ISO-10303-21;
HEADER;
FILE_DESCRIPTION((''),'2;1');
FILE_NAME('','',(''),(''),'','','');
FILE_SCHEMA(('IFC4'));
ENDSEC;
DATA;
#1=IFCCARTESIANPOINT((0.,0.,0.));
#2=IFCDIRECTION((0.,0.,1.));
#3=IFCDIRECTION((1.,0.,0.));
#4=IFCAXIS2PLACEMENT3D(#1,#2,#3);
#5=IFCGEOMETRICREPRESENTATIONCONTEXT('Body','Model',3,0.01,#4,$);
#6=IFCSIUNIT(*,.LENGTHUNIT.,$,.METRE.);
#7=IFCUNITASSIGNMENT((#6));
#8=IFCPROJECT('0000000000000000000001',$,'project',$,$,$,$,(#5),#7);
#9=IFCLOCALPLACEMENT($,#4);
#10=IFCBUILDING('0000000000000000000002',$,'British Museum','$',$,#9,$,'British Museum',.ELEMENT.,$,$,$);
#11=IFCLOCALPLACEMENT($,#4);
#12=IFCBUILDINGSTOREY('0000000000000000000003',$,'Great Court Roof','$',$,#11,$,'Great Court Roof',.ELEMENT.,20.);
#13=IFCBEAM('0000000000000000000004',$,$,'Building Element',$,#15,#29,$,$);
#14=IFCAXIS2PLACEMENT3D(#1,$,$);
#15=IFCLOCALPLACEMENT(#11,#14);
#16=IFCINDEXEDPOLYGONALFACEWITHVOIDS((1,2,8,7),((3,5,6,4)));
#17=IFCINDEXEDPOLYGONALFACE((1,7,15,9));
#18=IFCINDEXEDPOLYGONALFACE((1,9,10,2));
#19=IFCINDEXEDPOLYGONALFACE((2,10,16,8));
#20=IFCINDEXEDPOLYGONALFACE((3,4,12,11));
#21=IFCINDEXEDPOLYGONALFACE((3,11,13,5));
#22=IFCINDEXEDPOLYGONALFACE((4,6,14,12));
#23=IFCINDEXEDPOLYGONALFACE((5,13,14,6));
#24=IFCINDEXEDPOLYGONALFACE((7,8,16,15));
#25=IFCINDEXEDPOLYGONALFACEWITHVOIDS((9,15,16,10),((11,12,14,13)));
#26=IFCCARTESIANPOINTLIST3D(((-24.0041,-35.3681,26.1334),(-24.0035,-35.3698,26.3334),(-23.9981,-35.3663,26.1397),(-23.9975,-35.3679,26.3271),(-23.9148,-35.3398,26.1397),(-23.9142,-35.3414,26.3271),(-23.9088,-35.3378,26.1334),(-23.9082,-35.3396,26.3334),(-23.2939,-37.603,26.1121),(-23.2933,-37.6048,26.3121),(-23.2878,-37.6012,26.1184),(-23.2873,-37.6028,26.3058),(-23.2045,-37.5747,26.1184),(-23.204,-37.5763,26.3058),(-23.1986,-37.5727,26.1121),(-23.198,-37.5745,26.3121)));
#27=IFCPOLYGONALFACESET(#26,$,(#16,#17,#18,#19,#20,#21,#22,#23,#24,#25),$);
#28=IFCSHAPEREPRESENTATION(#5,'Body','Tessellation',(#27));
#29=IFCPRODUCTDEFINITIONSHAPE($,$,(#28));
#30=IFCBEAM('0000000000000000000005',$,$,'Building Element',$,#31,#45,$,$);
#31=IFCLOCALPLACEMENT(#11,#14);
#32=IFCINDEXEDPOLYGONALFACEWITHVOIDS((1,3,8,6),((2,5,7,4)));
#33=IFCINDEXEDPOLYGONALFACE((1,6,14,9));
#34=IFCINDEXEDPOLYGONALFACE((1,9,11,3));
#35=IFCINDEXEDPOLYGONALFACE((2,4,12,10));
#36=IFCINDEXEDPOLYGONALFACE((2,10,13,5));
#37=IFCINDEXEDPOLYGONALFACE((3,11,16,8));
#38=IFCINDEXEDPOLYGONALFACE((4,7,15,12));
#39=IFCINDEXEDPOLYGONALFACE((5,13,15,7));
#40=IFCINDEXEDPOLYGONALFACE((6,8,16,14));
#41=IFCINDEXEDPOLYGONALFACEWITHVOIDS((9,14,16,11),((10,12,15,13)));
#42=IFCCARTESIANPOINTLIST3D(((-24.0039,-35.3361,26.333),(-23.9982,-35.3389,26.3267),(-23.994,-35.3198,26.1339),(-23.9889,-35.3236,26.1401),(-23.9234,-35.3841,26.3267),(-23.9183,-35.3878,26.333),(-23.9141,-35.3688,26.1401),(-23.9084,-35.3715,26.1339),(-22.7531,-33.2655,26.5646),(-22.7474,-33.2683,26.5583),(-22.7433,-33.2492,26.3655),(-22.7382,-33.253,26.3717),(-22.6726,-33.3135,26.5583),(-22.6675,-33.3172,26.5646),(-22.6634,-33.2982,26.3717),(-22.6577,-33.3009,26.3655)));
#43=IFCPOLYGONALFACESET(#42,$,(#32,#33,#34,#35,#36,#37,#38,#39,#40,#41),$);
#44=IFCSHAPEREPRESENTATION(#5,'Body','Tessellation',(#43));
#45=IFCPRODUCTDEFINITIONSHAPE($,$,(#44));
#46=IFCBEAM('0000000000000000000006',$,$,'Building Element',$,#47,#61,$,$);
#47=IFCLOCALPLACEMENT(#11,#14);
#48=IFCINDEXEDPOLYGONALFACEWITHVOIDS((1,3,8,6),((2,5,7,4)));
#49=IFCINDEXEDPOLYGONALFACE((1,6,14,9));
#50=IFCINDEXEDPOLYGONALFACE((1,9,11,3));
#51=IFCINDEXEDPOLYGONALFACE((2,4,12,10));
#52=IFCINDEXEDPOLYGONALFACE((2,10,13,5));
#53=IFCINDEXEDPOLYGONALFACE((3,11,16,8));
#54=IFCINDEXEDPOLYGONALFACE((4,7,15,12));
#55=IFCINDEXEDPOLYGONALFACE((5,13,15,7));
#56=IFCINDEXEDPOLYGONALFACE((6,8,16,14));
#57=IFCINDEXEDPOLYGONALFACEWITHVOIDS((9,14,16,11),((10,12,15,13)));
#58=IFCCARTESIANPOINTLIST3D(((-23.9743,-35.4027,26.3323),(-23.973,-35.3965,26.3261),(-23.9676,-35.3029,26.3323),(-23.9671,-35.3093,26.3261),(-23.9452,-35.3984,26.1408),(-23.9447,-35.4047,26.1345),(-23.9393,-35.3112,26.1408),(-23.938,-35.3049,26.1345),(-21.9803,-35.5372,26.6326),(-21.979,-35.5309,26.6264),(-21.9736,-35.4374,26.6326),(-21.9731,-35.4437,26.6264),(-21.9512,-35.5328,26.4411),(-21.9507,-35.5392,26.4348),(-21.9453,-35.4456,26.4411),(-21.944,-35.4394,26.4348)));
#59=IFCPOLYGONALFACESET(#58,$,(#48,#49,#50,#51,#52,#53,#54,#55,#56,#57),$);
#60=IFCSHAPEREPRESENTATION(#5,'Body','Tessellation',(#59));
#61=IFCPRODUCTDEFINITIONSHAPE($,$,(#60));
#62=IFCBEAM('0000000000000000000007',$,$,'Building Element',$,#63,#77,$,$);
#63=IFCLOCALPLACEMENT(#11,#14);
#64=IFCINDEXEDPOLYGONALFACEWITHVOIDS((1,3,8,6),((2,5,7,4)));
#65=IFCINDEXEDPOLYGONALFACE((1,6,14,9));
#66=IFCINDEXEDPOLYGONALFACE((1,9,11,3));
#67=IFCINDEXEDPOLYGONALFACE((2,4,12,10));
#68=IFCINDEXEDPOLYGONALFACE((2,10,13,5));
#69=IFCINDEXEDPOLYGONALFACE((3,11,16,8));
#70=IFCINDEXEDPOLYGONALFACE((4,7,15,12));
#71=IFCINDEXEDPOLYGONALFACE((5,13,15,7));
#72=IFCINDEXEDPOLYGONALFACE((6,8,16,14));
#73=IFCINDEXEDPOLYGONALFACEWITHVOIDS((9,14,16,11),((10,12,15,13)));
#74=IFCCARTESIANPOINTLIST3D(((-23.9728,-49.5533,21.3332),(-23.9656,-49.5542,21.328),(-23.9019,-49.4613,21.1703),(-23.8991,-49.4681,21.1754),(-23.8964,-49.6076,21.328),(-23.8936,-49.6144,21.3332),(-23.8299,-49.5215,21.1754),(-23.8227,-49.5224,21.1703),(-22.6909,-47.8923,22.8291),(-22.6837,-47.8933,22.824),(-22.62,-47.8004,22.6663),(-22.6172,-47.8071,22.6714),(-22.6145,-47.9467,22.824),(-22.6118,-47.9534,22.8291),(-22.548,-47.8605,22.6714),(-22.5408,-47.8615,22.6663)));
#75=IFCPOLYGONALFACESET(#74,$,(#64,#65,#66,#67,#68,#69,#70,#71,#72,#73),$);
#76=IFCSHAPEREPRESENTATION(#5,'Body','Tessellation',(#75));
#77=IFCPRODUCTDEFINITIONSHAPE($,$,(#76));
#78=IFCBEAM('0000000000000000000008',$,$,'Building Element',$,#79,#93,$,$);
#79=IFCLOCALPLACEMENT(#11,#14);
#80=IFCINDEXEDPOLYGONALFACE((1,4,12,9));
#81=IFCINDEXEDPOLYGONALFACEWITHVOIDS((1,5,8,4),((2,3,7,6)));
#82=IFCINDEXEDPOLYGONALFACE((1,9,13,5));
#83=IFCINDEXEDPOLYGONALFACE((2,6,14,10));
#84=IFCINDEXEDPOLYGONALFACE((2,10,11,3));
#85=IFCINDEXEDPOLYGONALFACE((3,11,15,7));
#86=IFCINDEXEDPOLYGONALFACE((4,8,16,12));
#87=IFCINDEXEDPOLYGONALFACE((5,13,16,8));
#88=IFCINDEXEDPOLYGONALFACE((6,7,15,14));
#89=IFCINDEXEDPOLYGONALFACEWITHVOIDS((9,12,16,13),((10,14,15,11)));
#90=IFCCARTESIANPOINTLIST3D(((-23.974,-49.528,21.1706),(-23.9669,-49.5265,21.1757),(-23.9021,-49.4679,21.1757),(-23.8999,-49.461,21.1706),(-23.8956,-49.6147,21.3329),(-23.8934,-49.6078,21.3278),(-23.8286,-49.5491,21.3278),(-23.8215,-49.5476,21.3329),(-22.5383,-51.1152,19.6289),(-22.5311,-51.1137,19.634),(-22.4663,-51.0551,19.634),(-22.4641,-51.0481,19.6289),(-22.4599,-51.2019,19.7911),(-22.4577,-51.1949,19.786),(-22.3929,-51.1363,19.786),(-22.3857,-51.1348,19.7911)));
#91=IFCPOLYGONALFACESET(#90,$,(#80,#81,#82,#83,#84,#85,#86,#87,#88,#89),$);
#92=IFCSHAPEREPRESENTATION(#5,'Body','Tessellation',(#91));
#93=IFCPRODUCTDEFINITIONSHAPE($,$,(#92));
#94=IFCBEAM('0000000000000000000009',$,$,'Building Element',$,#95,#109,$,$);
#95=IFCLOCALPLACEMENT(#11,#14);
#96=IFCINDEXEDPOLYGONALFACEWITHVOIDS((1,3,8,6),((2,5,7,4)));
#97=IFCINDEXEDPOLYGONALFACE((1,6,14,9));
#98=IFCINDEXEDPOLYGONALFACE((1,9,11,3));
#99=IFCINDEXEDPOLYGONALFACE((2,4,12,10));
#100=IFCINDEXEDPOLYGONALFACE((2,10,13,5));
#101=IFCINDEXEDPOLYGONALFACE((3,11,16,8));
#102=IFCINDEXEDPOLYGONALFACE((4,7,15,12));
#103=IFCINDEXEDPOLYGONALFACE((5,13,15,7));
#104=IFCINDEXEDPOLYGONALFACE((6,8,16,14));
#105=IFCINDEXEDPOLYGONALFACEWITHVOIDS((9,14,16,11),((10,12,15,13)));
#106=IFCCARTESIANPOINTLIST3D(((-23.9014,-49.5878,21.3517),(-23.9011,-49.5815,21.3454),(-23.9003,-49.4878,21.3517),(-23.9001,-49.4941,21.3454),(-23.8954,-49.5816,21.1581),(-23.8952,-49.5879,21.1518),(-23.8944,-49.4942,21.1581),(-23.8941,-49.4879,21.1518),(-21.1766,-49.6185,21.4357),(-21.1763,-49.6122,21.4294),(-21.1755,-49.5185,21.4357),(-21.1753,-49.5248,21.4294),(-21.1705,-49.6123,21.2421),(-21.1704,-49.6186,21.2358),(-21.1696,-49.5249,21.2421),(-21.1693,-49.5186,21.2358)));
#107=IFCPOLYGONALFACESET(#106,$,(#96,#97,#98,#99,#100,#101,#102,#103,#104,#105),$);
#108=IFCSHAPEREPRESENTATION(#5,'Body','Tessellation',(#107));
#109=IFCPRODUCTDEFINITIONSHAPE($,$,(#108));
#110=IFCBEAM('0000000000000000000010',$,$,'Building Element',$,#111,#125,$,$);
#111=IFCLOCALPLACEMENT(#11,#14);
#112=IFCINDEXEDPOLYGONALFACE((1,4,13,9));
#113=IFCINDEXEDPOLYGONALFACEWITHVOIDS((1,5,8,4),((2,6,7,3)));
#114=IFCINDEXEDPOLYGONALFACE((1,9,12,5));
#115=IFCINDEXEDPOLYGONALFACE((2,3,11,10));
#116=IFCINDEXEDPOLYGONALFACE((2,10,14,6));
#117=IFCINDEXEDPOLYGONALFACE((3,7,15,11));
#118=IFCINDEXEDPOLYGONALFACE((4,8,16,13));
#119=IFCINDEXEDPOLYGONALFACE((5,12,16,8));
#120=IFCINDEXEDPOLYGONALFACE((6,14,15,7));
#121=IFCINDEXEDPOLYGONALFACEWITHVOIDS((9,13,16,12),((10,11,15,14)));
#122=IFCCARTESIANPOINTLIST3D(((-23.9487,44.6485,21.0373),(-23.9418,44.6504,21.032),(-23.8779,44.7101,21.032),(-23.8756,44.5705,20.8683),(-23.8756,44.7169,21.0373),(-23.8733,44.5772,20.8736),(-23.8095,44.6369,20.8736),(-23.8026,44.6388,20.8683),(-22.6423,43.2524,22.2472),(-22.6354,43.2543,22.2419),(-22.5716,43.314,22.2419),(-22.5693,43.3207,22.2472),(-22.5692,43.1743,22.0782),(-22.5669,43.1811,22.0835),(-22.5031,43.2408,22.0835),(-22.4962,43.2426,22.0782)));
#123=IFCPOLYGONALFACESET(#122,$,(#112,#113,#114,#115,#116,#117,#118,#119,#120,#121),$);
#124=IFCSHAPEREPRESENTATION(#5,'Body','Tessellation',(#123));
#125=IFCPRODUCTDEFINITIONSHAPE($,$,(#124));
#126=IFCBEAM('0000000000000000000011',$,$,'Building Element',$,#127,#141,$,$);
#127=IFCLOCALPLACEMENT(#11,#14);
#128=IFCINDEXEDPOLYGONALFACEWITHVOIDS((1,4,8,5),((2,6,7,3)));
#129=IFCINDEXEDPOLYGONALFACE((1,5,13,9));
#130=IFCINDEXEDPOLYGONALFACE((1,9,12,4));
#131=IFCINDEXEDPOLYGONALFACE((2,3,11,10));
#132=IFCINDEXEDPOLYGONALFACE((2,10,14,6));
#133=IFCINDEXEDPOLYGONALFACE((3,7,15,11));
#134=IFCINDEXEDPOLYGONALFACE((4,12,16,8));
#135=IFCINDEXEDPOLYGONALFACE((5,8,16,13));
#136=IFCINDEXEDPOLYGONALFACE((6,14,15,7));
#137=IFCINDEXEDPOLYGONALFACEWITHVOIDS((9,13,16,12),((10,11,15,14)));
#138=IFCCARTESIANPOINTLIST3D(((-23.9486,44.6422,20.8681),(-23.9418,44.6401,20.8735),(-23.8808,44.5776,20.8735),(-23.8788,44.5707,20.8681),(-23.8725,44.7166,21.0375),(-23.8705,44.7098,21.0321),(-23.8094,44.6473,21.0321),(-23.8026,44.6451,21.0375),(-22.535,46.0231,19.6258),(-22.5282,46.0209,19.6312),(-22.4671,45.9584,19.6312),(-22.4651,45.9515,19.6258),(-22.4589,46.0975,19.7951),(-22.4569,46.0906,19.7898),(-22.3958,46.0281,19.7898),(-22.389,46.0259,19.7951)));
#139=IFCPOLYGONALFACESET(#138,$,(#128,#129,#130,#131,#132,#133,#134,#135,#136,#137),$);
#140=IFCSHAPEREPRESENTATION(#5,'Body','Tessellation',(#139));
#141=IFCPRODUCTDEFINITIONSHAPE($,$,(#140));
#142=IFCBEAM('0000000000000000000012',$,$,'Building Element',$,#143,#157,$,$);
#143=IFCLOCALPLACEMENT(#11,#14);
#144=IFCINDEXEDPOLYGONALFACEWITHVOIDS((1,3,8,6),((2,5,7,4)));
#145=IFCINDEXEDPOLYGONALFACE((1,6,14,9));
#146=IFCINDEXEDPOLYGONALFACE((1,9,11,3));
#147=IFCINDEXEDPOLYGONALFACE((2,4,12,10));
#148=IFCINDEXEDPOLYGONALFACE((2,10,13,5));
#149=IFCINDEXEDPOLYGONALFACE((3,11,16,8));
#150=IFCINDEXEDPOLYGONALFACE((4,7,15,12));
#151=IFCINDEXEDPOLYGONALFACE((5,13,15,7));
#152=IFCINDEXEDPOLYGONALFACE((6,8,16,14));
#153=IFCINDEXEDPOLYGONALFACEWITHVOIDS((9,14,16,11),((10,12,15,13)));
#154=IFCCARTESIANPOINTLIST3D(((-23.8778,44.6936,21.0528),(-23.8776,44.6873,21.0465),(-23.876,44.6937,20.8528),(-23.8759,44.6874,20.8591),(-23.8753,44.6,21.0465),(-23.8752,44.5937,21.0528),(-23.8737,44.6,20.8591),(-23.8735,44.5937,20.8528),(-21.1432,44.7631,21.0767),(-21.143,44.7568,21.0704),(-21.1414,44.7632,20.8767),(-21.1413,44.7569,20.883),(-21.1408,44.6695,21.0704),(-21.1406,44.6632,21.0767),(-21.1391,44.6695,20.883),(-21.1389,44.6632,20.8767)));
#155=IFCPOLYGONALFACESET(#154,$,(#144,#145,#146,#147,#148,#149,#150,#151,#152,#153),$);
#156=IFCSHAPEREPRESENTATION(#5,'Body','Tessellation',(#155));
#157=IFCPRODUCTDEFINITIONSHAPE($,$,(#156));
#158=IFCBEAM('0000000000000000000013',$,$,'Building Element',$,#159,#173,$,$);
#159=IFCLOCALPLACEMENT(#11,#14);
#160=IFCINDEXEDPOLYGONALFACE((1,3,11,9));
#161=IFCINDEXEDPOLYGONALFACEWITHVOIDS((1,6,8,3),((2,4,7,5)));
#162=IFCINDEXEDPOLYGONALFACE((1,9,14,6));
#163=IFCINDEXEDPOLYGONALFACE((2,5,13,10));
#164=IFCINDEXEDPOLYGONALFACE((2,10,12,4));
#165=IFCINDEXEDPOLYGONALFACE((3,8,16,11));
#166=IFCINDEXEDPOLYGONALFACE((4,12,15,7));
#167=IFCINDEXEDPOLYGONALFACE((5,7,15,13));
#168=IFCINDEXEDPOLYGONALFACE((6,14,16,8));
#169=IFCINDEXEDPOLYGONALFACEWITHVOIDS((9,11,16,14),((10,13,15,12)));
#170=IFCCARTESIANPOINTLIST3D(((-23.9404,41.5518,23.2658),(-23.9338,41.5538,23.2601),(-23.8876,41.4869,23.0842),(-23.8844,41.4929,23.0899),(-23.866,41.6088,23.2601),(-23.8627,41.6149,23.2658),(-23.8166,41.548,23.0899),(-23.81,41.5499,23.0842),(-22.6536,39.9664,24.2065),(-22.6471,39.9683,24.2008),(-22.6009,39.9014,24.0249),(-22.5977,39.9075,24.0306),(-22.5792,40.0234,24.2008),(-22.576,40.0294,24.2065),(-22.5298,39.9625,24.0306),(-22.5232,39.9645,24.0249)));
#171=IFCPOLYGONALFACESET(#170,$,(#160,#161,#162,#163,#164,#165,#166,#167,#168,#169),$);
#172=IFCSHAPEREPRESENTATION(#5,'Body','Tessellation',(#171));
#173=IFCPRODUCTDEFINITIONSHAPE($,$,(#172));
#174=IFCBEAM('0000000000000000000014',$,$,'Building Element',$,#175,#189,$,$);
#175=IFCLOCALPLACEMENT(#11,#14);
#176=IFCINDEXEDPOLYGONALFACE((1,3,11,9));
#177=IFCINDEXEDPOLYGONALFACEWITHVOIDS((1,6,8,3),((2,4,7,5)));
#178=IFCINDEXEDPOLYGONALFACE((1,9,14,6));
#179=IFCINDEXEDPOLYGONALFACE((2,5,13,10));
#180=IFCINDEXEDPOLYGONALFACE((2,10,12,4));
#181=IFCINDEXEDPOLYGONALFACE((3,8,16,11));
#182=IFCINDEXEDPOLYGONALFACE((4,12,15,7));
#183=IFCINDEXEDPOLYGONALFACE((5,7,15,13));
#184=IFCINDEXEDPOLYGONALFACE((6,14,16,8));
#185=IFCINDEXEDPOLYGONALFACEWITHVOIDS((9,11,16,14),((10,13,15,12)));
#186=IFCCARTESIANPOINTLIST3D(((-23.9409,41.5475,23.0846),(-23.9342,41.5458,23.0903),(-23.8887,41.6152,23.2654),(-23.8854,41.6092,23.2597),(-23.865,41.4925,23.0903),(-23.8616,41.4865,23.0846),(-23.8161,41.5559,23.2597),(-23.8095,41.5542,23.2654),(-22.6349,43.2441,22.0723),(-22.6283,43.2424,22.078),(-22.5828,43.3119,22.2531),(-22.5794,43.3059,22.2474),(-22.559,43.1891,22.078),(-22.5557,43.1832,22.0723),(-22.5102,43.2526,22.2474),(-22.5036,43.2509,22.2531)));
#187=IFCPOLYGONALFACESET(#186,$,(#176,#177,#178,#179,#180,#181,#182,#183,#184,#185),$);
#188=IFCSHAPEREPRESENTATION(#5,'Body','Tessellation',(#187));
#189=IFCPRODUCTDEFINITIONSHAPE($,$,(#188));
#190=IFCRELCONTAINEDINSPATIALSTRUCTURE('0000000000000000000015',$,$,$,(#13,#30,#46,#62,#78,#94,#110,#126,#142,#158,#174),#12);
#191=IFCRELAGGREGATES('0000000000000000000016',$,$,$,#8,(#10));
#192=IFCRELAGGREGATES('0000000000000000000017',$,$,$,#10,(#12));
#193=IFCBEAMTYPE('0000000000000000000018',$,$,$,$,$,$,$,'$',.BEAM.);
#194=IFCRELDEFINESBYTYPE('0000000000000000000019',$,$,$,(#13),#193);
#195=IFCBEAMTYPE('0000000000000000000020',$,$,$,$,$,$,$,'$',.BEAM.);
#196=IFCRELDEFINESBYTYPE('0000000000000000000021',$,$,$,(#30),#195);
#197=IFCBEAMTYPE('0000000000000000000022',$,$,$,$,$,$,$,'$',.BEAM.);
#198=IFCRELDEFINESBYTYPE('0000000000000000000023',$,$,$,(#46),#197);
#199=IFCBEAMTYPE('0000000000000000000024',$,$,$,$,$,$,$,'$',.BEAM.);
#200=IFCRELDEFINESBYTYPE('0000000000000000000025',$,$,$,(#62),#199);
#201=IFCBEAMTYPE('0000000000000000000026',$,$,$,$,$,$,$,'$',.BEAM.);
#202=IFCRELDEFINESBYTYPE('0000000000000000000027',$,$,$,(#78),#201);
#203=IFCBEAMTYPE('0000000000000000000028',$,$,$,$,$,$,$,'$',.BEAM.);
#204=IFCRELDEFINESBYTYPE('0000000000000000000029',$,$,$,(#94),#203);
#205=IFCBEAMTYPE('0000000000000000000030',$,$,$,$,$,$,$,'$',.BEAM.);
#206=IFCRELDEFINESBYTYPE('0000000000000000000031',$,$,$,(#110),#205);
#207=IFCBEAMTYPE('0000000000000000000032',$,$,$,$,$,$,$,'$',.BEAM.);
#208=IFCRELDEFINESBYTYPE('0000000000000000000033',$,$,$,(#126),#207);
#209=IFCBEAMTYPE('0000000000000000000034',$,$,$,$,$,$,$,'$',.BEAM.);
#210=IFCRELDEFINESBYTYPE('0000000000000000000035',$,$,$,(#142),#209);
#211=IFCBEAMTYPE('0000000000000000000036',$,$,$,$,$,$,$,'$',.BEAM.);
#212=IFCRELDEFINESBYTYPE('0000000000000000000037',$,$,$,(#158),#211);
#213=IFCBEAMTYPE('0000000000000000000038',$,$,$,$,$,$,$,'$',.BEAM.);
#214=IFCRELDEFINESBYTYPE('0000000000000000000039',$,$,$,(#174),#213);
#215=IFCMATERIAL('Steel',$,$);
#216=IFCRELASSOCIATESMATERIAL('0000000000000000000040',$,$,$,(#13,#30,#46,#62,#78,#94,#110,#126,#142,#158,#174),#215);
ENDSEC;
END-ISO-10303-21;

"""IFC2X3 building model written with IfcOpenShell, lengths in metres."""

from ifc_helpers import new_model, si_unit, frame, origin_with_axes, origin_2d, place, context, project, spatial, hollow_rectangle, extrude, material, type_object, element, save


model = new_model("IFC2X3")

# Units and contexts
model_context = context("Model", 3, precision=0.01, world=origin_with_axes(), identifier="Body")
ifc_project = project(units=[si_unit("LENGTHUNIT", "METRE")], contexts=[model_context])

# Building, storey
building_placement = place(None, origin_with_axes())
building = spatial("IfcBuilding", under=ifc_project, at=building_placement, Name="British Museum", Description="$", LongName="British Museum", CompositionType="ELEMENT")
storey_placement = place(None, origin_with_axes())
storey = spatial("IfcBuildingStorey", under=building, at=storey_placement, Name="Great Court Roof", Description="$", LongName="Great Court Roof", CompositionType="ELEMENT", Elevation=20.0)

# Beams
ifc_material = material(Name="Steel")
beam_type_1 = type_object("IfcBeamType", ElementType="$", PredefinedType="BEAM")
beam_1_placement = place(None, origin_with_axes())
element("IfcBeam", 1, at=beam_1_placement, inside=storey, type_object=beam_type_1, material=ifc_material, Description="Building Element", context=model_context, shape_type="SweptSolid", body=[
    extrude(hollow_rectangle(XDim=0.1, YDim=0.2, WallThickness=0.0063, InnerFilletRadius=-0.0063, OuterFilletRadius=0.0, at=origin_2d()), frame((-23.9561, -35.3538, 26.2334), z_axis=(0.302842, -0.952997, -0.009081), x_axis=(0.953037, 0.302855, 0.0)), (0.0, 0.0, 1.0), 2.3452),
])
beam_type_2 = type_object("IfcBeamType", ElementType="$", PredefinedType="BEAM")
beam_2_placement = place(None, origin_with_axes())
element("IfcBeam", 2, at=beam_2_placement, inside=storey, type_object=beam_type_2, material=ifc_material, Description="Building Element", context=model_context, shape_type="SweptSolid", body=[
    extrude(hollow_rectangle(XDim=0.1, YDim=0.2, WallThickness=0.0063, InnerFilletRadius=-0.0063, OuterFilletRadius=0.0, at=origin_2d()), frame((-23.9561, -35.3538, 26.2334), z_axis=(0.514682, 0.852068, 0.095308), x_axis=(-0.855964, 0.517035, 0.0)), (0.0, 0.0, 1.0), 2.4301),
])
beam_type_3 = type_object("IfcBeamType", ElementType="$", PredefinedType="BEAM")
beam_3_placement = place(None, origin_with_axes())
element("IfcBeam", 3, at=beam_3_placement, inside=storey, type_object=beam_type_3, material=ifc_material, Description="Building Element", context=model_context, shape_type="SweptSolid", body=[
    extrude(hollow_rectangle(XDim=0.1, YDim=0.2, WallThickness=0.0063, InnerFilletRadius=-0.0063, OuterFilletRadius=0.0, at=origin_2d()), frame((-23.9561, -35.3538, 26.2334), z_axis=(0.986657, -0.066531, 0.1486), x_axis=(0.067278, 0.997734, 0.0)), (0.0, 0.0, 1.0), 2.021),
])
beam_type_4 = type_object("IfcBeamType", ElementType="$", PredefinedType="BEAM")
beam_4_placement = place(None, origin_with_axes())
element("IfcBeam", 4, at=beam_4_placement, inside=storey, type_object=beam_type_4, material=ifc_material, Description="Building Element", context=model_context, shape_type="SweptSolid", body=[
    extrude(hollow_rectangle(XDim=0.1, YDim=0.2, WallThickness=0.0063, InnerFilletRadius=-0.0063, OuterFilletRadius=0.0, at=origin_2d()), frame((-23.8977, -49.5378, 21.2517), z_axis=(0.497468, 0.644578, 0.580555), x_axis=(-0.79165, 0.610975, 0.0)), (0.0, 0.0, 1.0), 2.5768),
])
beam_type_5 = type_object("IfcBeamType", ElementType="$", PredefinedType="BEAM")
beam_5_placement = place(None, origin_with_axes())
element("IfcBeam", 5, at=beam_5_placement, inside=storey, type_object=beam_type_5, material=ifc_material, Description="Building Element", context=model_context, shape_type="SweptSolid", body=[
    extrude(hollow_rectangle(XDim=0.1, YDim=0.2, WallThickness=0.0063, InnerFilletRadius=-0.0063, OuterFilletRadius=0.0, at=origin_2d()), frame((-23.8977, -49.5378, 21.2517), z_axis=(0.544321, -0.601723, -0.584503), x_axis=(0.741594, 0.670849, 0.0)), (0.0, 0.0, 1.0), 2.6377),
])
beam_type_6 = type_object("IfcBeamType", ElementType="$", PredefinedType="BEAM")
beam_6_placement = place(None, origin_with_axes())
element("IfcBeam", 6, at=beam_6_placement, inside=storey, type_object=beam_type_6, material=ifc_material, Description="Building Element", context=model_context, shape_type="SweptSolid", body=[
    extrude(hollow_rectangle(XDim=0.1, YDim=0.2, WallThickness=0.0063, InnerFilletRadius=-0.0063, OuterFilletRadius=0.0, at=origin_2d()), frame((-23.8977, -49.5378, 21.2517), z_axis=(0.999461, -0.011261, 0.030821), x_axis=(0.011266, 0.999937, 0.0)), (0.0, 0.0, 1.0), 2.7263),
])
beam_type_7 = type_object("IfcBeamType", ElementType="$", PredefinedType="BEAM")
beam_7_placement = place(None, origin_with_axes())
element("IfcBeam", 7, at=beam_7_placement, inside=storey, type_object=beam_type_7, material=ifc_material, Description="Building Element", context=model_context, shape_type="SweptSolid", body=[
    extrude(hollow_rectangle(XDim=0.1, YDim=0.2, WallThickness=0.0063, InnerFilletRadius=-0.0063, OuterFilletRadius=0.0, at=origin_2d()), frame((-23.8756, 44.6437, 20.9528), z_axis=(0.577362, -0.617034, 0.534717), x_axis=(0.730191, 0.683243, 0.0)), (0.0, 0.0, 1.0), 2.2627),
])
beam_type_8 = type_object("IfcBeamType", ElementType="$", PredefinedType="BEAM")
beam_8_placement = place(None, origin_with_axes())
element("IfcBeam", 8, at=beam_8_placement, inside=storey, type_object=beam_type_8, material=ifc_material, Description="Building Element", context=model_context, shape_type="SweptSolid", body=[
    extrude(hollow_rectangle(XDim=0.1, YDim=0.2, WallThickness=0.0063, InnerFilletRadius=-0.0063, OuterFilletRadius=0.0, at=origin_2d()), frame((-23.8756, 44.6437, 20.9528), z_axis=(0.605619, 0.591572, -0.53223), x_axis=(-0.698762, 0.715354, 0.0)), (0.0, 0.0, 1.0), 2.3342),
])
beam_type_9 = type_object("IfcBeamType", ElementType="$", PredefinedType="BEAM")
beam_9_placement = place(None, origin_with_axes())
element("IfcBeam", 9, at=beam_9_placement, inside=storey, type_object=beam_type_9, material=ifc_material, Description="Building Element", context=model_context, shape_type="SweptSolid", body=[
    extrude(hollow_rectangle(XDim=0.1, YDim=0.2, WallThickness=0.0063, InnerFilletRadius=-0.0063, OuterFilletRadius=0.0, at=origin_2d()), frame((-23.8756, 44.6437, 20.9528), z_axis=(0.999639, 0.025412, 0.008721), x_axis=(-0.025413, 0.999677, 0.0)), (0.0, 0.0, 1.0), 2.7356),
])
beam_type_10 = type_object("IfcBeamType", ElementType="$", PredefinedType="BEAM")
beam_10_placement = place(None, origin_with_axes())
element("IfcBeam", 10, at=beam_10_placement, inside=storey, type_object=beam_type_10, material=ifc_material, Description="Building Element", context=model_context, shape_type="SweptSolid", body=[
    extrude(hollow_rectangle(XDim=0.1, YDim=0.2, WallThickness=0.0063, InnerFilletRadius=-0.0063, OuterFilletRadius=0.0, at=origin_2d()), frame((-23.8752, 41.5509, 23.175), z_axis=(0.57236, -0.705203, 0.418441), x_axis=(0.776446, 0.630183, 0.0)), (0.0, 0.0, 1.0), 2.2482),
])
beam_type_11 = type_object("IfcBeamType", ElementType="$", PredefinedType="BEAM")
beam_11_placement = place(None, origin_with_axes())
element("IfcBeam", 11, at=beam_11_placement, inside=storey, type_object=beam_type_11, material=ifc_material, Description="Building Element", context=model_context, shape_type="SweptSolid", body=[
    extrude(hollow_rectangle(XDim=0.1, YDim=0.2, WallThickness=0.0063, InnerFilletRadius=-0.0063, OuterFilletRadius=0.0, at=origin_2d()), frame((-23.8752, 41.5509, 23.175), z_axis=(0.551421, 0.716402, -0.427438), x_axis=(-0.792441, 0.609948, 0.0)), (0.0, 0.0, 1.0), 2.3683),
])

save(model, "model.ifc")
